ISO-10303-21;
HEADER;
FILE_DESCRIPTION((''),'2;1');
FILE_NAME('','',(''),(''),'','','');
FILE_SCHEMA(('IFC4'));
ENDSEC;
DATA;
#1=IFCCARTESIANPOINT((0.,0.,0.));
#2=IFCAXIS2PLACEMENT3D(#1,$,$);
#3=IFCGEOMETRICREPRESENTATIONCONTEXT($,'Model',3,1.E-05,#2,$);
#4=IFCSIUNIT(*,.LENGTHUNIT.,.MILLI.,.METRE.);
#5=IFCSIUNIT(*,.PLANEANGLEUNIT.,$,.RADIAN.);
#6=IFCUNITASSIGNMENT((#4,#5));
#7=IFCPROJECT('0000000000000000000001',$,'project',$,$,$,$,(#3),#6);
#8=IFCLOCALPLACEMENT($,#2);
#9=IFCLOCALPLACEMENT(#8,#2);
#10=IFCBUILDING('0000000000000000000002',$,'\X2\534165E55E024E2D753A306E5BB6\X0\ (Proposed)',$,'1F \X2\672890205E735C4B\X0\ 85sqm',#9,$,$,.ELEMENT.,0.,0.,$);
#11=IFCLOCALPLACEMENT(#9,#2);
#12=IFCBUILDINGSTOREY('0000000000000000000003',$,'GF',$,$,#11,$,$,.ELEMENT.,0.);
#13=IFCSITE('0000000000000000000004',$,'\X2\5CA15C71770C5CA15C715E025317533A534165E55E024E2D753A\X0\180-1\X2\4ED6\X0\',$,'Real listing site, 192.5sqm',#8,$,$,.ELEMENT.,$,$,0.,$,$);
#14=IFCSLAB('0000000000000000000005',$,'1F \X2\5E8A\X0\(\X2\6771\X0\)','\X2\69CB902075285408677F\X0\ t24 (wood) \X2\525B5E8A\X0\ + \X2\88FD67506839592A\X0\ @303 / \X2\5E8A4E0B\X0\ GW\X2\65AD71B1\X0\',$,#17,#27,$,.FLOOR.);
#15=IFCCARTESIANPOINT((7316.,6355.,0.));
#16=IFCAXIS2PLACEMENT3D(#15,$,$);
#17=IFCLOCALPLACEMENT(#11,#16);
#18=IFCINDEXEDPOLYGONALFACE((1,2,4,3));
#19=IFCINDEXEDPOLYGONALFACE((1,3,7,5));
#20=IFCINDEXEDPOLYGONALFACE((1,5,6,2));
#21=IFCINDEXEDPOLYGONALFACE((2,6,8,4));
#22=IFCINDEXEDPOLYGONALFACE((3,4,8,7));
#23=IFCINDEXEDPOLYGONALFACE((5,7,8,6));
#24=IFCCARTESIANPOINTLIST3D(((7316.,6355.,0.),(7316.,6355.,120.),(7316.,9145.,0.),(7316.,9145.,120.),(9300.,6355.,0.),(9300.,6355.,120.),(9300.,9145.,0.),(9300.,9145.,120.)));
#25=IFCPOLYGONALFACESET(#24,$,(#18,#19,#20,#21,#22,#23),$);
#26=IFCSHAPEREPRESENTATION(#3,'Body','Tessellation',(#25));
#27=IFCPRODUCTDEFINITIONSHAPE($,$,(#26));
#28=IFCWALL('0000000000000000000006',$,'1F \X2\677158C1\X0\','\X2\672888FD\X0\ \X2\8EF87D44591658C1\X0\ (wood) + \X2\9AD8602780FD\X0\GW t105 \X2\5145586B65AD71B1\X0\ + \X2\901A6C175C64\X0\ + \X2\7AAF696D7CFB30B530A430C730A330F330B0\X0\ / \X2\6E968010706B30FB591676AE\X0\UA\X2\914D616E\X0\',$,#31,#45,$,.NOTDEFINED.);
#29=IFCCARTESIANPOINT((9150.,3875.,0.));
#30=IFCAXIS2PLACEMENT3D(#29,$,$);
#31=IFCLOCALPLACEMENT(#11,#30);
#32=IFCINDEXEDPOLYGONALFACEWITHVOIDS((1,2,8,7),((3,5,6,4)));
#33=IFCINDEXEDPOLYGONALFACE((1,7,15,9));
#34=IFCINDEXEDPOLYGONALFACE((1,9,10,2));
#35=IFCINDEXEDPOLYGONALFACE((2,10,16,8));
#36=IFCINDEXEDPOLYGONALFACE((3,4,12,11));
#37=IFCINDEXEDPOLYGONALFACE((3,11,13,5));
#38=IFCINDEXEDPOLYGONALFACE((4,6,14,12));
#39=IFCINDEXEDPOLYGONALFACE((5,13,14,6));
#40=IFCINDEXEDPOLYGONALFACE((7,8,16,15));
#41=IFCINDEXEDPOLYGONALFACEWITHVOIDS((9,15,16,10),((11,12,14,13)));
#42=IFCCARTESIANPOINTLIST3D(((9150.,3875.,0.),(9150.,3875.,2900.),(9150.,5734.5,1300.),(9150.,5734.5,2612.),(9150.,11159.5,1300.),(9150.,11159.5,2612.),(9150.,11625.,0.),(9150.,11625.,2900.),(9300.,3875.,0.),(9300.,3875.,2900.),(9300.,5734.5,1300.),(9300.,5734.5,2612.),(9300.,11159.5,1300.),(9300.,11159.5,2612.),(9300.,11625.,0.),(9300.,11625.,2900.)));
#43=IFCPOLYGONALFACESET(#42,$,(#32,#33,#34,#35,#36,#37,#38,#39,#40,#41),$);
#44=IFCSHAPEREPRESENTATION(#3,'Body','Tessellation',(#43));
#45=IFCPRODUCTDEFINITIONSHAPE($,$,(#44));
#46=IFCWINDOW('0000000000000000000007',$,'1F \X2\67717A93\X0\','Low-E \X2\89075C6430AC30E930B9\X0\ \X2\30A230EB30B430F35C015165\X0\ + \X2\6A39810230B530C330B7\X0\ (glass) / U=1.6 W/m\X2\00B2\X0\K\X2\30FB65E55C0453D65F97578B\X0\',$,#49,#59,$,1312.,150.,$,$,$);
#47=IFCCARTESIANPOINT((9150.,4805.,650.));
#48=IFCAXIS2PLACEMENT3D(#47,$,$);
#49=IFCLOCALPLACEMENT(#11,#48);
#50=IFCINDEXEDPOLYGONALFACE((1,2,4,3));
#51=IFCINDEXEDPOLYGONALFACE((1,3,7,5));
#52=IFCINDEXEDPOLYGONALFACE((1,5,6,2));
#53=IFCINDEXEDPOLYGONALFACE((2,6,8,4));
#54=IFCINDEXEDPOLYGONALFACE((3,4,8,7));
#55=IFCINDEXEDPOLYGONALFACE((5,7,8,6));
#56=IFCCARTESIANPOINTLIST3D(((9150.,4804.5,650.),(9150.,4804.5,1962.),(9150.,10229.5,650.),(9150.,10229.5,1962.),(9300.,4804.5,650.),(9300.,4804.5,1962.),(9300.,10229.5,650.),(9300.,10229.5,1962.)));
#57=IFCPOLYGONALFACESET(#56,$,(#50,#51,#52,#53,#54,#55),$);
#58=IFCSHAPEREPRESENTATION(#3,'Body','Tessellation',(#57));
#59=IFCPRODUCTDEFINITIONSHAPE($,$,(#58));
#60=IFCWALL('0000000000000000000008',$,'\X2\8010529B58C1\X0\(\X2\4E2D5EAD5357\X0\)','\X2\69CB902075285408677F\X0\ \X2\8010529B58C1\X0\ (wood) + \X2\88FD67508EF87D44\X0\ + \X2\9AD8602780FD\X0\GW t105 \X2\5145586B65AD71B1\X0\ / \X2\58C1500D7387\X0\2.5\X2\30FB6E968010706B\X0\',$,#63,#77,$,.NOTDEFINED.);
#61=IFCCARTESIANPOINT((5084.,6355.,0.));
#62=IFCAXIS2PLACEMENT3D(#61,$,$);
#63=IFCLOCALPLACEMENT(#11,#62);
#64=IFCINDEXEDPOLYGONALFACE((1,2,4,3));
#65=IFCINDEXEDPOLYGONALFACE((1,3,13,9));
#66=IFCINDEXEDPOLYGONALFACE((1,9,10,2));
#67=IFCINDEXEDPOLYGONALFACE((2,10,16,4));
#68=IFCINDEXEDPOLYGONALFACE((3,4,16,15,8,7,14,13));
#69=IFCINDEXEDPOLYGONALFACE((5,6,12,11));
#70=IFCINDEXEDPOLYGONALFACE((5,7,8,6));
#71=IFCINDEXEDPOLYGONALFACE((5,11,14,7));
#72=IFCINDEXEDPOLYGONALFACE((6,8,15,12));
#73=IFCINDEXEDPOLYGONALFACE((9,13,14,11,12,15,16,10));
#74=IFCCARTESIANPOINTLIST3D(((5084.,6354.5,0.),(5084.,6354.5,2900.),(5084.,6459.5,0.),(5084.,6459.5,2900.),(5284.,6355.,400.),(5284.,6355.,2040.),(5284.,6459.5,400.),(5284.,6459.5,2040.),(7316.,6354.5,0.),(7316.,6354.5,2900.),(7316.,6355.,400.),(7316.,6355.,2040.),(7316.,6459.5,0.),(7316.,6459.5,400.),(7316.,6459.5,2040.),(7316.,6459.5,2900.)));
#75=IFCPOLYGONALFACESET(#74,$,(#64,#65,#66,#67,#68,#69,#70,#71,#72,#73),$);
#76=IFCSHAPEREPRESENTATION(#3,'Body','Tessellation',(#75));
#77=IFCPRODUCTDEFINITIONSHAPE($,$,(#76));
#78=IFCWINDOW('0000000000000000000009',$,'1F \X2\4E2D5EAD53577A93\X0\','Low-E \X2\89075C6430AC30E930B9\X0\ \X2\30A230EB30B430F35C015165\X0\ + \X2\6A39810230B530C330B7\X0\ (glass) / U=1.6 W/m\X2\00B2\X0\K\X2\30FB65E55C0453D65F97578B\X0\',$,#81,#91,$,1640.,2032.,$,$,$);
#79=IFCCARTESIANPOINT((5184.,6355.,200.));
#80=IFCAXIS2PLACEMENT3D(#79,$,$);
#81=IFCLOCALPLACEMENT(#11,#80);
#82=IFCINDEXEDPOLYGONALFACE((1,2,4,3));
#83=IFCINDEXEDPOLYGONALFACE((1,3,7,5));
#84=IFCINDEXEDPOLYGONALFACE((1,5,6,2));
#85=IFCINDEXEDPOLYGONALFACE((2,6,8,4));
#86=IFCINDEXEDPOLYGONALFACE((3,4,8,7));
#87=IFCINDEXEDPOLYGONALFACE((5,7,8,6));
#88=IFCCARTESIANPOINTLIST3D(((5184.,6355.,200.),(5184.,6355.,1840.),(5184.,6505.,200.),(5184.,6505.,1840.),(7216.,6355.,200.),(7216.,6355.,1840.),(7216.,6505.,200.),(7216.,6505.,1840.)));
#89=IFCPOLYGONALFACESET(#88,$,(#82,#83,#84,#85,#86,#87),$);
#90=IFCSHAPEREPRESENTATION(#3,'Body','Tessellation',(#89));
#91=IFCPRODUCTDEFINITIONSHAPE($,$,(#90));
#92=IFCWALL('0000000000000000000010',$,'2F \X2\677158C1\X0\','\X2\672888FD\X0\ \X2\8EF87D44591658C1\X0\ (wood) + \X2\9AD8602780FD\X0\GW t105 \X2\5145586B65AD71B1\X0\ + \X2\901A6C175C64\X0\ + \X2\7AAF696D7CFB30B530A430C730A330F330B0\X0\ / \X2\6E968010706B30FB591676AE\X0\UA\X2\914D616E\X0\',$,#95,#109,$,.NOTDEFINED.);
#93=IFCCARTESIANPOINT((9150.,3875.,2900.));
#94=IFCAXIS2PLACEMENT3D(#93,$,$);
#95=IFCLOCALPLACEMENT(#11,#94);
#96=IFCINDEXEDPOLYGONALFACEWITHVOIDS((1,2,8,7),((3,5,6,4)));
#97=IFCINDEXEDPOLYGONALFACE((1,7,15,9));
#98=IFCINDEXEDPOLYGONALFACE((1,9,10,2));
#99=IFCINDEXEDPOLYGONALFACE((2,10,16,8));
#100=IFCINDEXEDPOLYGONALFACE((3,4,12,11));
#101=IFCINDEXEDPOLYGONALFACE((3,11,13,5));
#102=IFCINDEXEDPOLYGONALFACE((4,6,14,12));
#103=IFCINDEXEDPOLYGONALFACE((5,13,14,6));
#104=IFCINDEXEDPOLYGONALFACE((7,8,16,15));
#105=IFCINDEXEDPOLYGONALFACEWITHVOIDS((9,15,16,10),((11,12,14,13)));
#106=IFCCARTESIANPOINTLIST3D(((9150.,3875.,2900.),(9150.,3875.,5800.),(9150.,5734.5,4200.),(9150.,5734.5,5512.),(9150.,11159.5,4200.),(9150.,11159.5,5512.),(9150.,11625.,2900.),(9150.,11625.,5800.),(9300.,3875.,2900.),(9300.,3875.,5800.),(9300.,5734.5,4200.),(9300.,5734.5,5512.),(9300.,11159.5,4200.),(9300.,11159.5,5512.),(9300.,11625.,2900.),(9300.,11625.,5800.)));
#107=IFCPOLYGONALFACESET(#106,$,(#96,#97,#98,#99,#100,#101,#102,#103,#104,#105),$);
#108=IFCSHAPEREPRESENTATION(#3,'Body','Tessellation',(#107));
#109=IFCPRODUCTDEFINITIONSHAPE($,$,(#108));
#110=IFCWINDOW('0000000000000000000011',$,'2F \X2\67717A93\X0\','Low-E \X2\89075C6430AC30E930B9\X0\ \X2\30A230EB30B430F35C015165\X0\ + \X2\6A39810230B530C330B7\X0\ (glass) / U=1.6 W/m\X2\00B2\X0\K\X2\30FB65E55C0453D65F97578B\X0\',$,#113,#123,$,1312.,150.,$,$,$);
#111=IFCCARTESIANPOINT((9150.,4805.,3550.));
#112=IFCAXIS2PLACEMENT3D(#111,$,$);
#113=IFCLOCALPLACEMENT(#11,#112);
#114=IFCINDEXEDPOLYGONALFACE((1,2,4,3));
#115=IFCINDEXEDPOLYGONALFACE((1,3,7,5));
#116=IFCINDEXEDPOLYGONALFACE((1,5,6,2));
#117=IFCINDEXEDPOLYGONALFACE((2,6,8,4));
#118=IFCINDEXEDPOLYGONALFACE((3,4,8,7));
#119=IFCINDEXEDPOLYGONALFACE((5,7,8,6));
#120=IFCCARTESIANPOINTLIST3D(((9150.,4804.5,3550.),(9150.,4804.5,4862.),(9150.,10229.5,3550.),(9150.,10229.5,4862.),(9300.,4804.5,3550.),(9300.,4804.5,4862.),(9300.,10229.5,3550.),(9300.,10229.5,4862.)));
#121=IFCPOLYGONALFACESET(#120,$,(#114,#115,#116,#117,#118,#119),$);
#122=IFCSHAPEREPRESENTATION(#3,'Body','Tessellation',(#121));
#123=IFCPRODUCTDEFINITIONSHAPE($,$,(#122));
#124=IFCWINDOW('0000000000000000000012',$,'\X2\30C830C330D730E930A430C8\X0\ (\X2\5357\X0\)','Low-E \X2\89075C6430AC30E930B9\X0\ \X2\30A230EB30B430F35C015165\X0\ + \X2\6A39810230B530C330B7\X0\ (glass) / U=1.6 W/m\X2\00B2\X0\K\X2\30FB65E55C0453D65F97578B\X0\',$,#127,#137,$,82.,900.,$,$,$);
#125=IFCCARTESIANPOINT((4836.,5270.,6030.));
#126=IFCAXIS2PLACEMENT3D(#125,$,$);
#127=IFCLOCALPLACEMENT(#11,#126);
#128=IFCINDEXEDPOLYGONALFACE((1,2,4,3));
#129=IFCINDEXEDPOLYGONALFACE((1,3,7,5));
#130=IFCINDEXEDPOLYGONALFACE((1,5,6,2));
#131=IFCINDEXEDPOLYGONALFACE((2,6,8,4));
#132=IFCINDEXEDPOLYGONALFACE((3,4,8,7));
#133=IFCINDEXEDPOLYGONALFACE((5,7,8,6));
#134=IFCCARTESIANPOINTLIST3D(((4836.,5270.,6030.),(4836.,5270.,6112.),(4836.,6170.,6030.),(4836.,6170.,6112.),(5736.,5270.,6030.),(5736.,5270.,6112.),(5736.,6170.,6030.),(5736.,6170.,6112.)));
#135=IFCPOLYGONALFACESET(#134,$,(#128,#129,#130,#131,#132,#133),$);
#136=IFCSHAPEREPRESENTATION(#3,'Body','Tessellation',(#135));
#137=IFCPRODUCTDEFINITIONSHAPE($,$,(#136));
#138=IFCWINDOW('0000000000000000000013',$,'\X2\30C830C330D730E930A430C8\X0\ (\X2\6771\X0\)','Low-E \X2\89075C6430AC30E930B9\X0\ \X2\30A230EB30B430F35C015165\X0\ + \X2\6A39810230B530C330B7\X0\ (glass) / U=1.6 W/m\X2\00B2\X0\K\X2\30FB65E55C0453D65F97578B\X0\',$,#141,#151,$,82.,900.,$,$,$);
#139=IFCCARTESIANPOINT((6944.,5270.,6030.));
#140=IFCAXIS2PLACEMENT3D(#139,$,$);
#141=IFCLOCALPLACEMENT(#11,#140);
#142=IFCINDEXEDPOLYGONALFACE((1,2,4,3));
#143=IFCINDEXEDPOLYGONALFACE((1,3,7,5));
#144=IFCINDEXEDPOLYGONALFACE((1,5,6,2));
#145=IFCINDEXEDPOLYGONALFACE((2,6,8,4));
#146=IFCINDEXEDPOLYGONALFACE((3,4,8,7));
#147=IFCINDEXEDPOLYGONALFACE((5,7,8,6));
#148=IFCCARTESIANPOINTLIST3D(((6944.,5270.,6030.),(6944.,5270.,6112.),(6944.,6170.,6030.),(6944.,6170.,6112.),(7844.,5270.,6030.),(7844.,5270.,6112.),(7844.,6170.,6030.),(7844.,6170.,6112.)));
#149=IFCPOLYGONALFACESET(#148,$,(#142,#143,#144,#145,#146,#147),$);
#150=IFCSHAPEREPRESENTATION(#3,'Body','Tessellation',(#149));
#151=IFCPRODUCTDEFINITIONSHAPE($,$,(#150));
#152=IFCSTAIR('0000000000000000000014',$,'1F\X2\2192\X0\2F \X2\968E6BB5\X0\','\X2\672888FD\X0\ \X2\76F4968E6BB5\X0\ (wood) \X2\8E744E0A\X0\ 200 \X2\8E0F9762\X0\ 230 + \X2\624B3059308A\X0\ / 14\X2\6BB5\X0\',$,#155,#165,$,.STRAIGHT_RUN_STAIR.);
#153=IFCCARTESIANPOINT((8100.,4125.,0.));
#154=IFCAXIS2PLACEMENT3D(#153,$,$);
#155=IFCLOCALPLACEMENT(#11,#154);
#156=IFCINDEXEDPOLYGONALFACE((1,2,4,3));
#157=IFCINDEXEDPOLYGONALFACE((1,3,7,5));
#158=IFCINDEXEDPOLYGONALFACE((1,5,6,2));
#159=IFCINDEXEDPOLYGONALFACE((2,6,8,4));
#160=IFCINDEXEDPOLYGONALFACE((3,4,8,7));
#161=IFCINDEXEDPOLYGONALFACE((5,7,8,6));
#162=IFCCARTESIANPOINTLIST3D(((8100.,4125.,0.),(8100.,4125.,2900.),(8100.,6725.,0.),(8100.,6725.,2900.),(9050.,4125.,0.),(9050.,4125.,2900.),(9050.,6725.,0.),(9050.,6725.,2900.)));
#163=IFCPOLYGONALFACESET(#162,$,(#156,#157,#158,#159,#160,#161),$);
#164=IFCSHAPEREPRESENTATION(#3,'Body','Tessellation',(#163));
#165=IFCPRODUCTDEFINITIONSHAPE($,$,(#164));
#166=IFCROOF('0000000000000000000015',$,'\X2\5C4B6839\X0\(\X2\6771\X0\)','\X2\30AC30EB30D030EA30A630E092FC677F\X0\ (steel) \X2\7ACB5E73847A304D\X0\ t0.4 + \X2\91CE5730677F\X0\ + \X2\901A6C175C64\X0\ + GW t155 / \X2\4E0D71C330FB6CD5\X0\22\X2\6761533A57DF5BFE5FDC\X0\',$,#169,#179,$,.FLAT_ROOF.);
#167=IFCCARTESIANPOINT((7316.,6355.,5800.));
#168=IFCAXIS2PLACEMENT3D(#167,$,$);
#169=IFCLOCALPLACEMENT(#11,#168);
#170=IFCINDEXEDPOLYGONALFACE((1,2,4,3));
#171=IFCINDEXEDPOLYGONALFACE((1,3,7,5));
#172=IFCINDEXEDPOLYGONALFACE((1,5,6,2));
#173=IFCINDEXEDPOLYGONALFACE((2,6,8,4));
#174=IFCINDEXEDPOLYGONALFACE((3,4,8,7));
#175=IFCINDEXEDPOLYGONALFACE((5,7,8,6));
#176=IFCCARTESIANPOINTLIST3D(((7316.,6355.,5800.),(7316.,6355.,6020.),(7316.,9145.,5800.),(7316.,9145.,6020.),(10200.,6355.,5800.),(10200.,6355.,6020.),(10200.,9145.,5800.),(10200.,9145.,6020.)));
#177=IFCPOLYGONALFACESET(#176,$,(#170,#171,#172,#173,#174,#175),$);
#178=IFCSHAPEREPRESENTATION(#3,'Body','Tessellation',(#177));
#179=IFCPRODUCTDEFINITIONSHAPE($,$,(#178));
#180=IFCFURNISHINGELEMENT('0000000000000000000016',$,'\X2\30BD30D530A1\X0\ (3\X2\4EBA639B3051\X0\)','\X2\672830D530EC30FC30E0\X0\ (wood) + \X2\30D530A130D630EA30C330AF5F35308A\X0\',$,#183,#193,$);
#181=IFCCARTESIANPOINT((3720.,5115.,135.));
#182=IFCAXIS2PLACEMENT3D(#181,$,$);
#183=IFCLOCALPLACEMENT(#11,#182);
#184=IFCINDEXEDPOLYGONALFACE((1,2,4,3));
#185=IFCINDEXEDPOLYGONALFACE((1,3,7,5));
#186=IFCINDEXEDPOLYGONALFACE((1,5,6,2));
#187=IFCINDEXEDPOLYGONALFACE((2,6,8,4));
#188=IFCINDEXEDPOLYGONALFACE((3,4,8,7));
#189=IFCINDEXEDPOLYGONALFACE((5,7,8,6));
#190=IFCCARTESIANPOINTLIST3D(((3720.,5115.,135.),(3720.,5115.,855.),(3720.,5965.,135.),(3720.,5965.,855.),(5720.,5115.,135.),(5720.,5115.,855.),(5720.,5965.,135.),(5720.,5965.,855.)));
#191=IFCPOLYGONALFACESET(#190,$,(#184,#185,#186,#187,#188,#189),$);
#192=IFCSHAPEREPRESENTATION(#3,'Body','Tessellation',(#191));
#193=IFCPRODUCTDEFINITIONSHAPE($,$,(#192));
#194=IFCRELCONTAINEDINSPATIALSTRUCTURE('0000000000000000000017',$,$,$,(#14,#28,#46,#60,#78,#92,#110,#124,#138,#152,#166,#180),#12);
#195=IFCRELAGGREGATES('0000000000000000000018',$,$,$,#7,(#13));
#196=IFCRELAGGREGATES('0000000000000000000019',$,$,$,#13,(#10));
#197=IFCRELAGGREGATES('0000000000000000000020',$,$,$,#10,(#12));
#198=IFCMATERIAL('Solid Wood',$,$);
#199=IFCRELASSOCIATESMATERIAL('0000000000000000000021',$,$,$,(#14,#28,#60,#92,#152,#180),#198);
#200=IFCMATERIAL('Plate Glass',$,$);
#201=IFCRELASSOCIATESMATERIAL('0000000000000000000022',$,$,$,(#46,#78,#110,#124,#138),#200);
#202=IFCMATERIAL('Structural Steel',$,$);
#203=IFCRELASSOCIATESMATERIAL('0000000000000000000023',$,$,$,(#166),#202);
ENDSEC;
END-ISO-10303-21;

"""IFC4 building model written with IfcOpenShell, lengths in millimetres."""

from ifc_helpers import new_model, si_unit, frame, frame_2d, origin, place, context, project, spatial, rectangle, extrude, material, element, fill, save


model = new_model("IFC4")

# Units and contexts
model_context = context("Model", 3, precision=1e-05, world=origin())
ifc_project = project(units=[si_unit("LENGTHUNIT", "METRE", prefix="MILLI"), si_unit("PLANEANGLEUNIT", "RADIAN")], contexts=[model_context])

# Site, building, storey
site_placement = place(None, origin())
site = spatial("IfcSite", under=ifc_project, at=site_placement, Name="岡山県岡山市北区十日市中町180-1他", ObjectType="Real listing site, 192.5sqm", CompositionType="ELEMENT", RefElevation=0.0)
building_placement = place(site_placement, origin())
building = spatial("IfcBuilding", under=site, at=building_placement, Name="十日市中町の家 (Proposed)", ObjectType="1F 木造平屋 85sqm", CompositionType="ELEMENT", ElevationOfRefHeight=0.0, ElevationOfTerrain=0.0)
storey_placement = place(building_placement, origin())
storey = spatial("IfcBuildingStorey", under=building, at=storey_placement, Name="GF", CompositionType="ELEMENT", Elevation=0.0)

# Slab
ifc_material_1 = material(Name="Solid Wood")
slab_placement = place(storey_placement, frame((7316.0, 6355.0, 0.0)))
element("IfcSlab", 1, at=slab_placement, inside=storey, material=ifc_material_1, Name="1F 床(東)", Description="構造用合板 t24 (wood) 剛床 + 製材根太 @303 / 床下 GW断熱", PredefinedType="FLOOR", context=model_context, shape_type="SweptSolid", body=[
    extrude(rectangle(XDim=1984.0, YDim=2790.0, at=frame_2d((992.0, 1395.0))), frame((7316.0, 6355.0, 0.0)), (0.0, 0.0, 1.0), 120.0),
])

# Walls, openings, windows
wall_1_placement = place(storey_placement, frame((9150.0, 3875.0, 0.0)))
wall_1 = element("IfcWall", 2, at=wall_1_placement, inside=storey, material=ifc_material_1, Name="1F 東壁", Description="木製 軸組外壁 (wood) + 高性能GW t105 充填断熱 + 通気層 + 窯業系サイディング / 準耐火・外皮UA配慮", PredefinedType="NOTDEFINED", context=model_context, shape_type="SweptSolid", body=[
    extrude(rectangle(XDim=150.0, YDim=7750.0, at=frame_2d((75.0, 3875.0))), frame((9150.0, 3875.0, 0.0)), (0.0, 0.0, 1.0), 2900.0),
])
opening_1_placement = place(storey_placement, frame((9150.0, 4805.0, 650.0)))
opening_1 = element("IfcOpeningElement", 3, at=opening_1_placement, cuts=wall_1, PredefinedType="NOTDEFINED", context=model_context, shape_type="SweptSolid", body=[
    extrude(rectangle(XDim=150.0, YDim=5425.0, at=frame_2d((75.0, 2712.0))), frame((9150.0, 4805.0, 650.0)), (0.0, 0.0, 1.0), 1312.0),
])
ifc_material_2 = material(Name="Plate Glass")
window_1_placement = place(storey_placement, frame((9150.0, 4805.0, 650.0)))
window_1 = element("IfcWindow", 4, at=window_1_placement, inside=storey, material=ifc_material_2, Name="1F 東窓", Description="Low-E 複層ガラス アルゴン封入 + 樹脂サッシ (glass) / U=1.6 W/m²K・日射取得型", OverallHeight=1312.0, OverallWidth=150.0, context=model_context, shape_type="SweptSolid", body=[
    extrude(rectangle(XDim=150.0, YDim=5425.0, at=frame_2d((75.0, 2712.0))), frame((9150.0, 4805.0, 650.0)), (0.0, 0.0, 1.0), 1312.0),
])
fill(opening_1, window_1)
wall_2_placement = place(storey_placement, frame((5084.0, 6355.0, 0.0)))
wall_2 = element("IfcWall", 5, at=wall_2_placement, inside=storey, material=ifc_material_1, Name="耐力壁(中庭南)", Description="構造用合板 耐力壁 (wood) + 製材軸組 + 高性能GW t105 充填断熱 / 壁倍率2.5・準耐火", PredefinedType="NOTDEFINED", context=model_context, shape_type="SweptSolid", body=[
    extrude(rectangle(XDim=2232.0, YDim=105.0, at=frame_2d((1116.0, 52.0))), frame((5084.0, 6355.0, 0.0)), (0.0, 0.0, 1.0), 2900.0),
])
opening_2_placement = place(storey_placement, frame((5184.0, 6355.0, 200.0)))
opening_2 = element("IfcOpeningElement", 6, at=opening_2_placement, cuts=wall_2, PredefinedType="NOTDEFINED", context=model_context, shape_type="SweptSolid", body=[
    extrude(rectangle(XDim=2032.0, YDim=150.0, at=frame_2d((1016.0, 75.0))), frame((5184.0, 6355.0, 200.0)), (0.0, 0.0, 1.0), 1640.0),
])
window_2_placement = place(storey_placement, frame((5184.0, 6355.0, 200.0)))
window_2 = element("IfcWindow", 7, at=window_2_placement, inside=storey, material=ifc_material_2, Name="1F 中庭南窓", Description="Low-E 複層ガラス アルゴン封入 + 樹脂サッシ (glass) / U=1.6 W/m²K・日射取得型", OverallHeight=1640.0, OverallWidth=2032.0, context=model_context, shape_type="SweptSolid", body=[
    extrude(rectangle(XDim=2032.0, YDim=150.0, at=frame_2d((1016.0, 75.0))), frame((5184.0, 6355.0, 200.0)), (0.0, 0.0, 1.0), 1640.0),
])
fill(opening_2, window_2)

# Wall, opening, window
wall_3_placement = place(storey_placement, frame((9150.0, 3875.0, 2900.0)))
wall_3 = element("IfcWall", 8, at=wall_3_placement, inside=storey, material=ifc_material_1, Name="2F 東壁", Description="木製 軸組外壁 (wood) + 高性能GW t105 充填断熱 + 通気層 + 窯業系サイディング / 準耐火・外皮UA配慮", PredefinedType="NOTDEFINED", context=model_context, shape_type="SweptSolid", body=[
    extrude(rectangle(XDim=150.0, YDim=7750.0, at=frame_2d((75.0, 3875.0))), frame((9150.0, 3875.0, 2900.0)), (0.0, 0.0, 1.0), 2900.0),
])
opening_3_placement = place(storey_placement, frame((9150.0, 4805.0, 3550.0)))
opening_3 = element("IfcOpeningElement", 9, at=opening_3_placement, cuts=wall_3, PredefinedType="NOTDEFINED", context=model_context, shape_type="SweptSolid", body=[
    extrude(rectangle(XDim=150.0, YDim=5425.0, at=frame_2d((75.0, 2712.0))), frame((9150.0, 4805.0, 3550.0)), (0.0, 0.0, 1.0), 1312.0),
])
window_3_placement = place(storey_placement, frame((9150.0, 4805.0, 3550.0)))
window_3 = element("IfcWindow", 10, at=window_3_placement, inside=storey, material=ifc_material_2, Name="2F 東窓", Description="Low-E 複層ガラス アルゴン封入 + 樹脂サッシ (glass) / U=1.6 W/m²K・日射取得型", OverallHeight=1312.0, OverallWidth=150.0, context=model_context, shape_type="SweptSolid", body=[
    extrude(rectangle(XDim=150.0, YDim=5425.0, at=frame_2d((75.0, 2712.0))), frame((9150.0, 4805.0, 3550.0)), (0.0, 0.0, 1.0), 1312.0),
])
fill(opening_3, window_3)

# Windows
window_4_placement = place(storey_placement, frame((4836.0, 5270.0, 6030.0)))
element("IfcWindow", 11, at=window_4_placement, inside=storey, material=ifc_material_2, Name="トップライト (南)", Description="Low-E 複層ガラス アルゴン封入 + 樹脂サッシ (glass) / U=1.6 W/m²K・日射取得型", OverallHeight=82.0, OverallWidth=900.0, context=model_context, shape_type="SweptSolid", body=[
    extrude(rectangle(XDim=900.0, YDim=900.0, at=frame_2d((450.0, 450.0))), frame((4836.0, 5270.0, 6030.0)), (0.0, 0.0, 1.0), 82.0),
])
window_5_placement = place(storey_placement, frame((6944.0, 5270.0, 6030.0)))
element("IfcWindow", 12, at=window_5_placement, inside=storey, material=ifc_material_2, Name="トップライト (東)", Description="Low-E 複層ガラス アルゴン封入 + 樹脂サッシ (glass) / U=1.6 W/m²K・日射取得型", OverallHeight=82.0, OverallWidth=900.0, context=model_context, shape_type="SweptSolid", body=[
    extrude(rectangle(XDim=900.0, YDim=900.0, at=frame_2d((450.0, 450.0))), frame((6944.0, 5270.0, 6030.0)), (0.0, 0.0, 1.0), 82.0),
])

# Stair
stair_placement = place(storey_placement, frame((8100.0, 4125.0, 0.0)))
element("IfcStair", 13, at=stair_placement, inside=storey, material=ifc_material_1, Name="1F→2F 階段", Description="木製 直階段 (wood) 蹴上 200 踏面 230 + 手すり / 14段", PredefinedType="STRAIGHT_RUN_STAIR", context=model_context, shape_type="SweptSolid", body=[
    extrude(rectangle(XDim=950.0, YDim=2600.0, at=frame_2d((475.0, 1300.0))), frame((8100.0, 4125.0, 0.0)), (0.0, 0.0, 1.0), 2900.0),
])

# Roof
ifc_material_3 = material(Name="Structural Steel")
roof_placement = place(storey_placement, frame((7316.0, 6355.0, 5800.0)))
element("IfcRoof", 14, at=roof_placement, inside=storey, material=ifc_material_3, Name="屋根(東)", Description="ガルバリウム鋼板 (steel) 立平葺き t0.4 + 野地板 + 通気層 + GW t155 / 不燃・法22条区域対応", PredefinedType="FLAT_ROOF", context=model_context, shape_type="SweptSolid", body=[
    extrude(rectangle(XDim=2884.0, YDim=2790.0, at=frame_2d((1442.0, 1395.0))), frame((7316.0, 6355.0, 5800.0)), (0.0, 0.0, 1.0), 220.0),
])

# Furnishing element
furnishing_1_placement = place(storey_placement, frame((3720.0, 5115.0, 135.0)))
element("IfcFurnishingElement", 15, at=furnishing_1_placement, inside=storey, material=ifc_material_1, Name="ソファ (3人掛け)", Description="木フレーム (wood) + ファブリック張り", context=model_context, shape_type="SweptSolid", body=[
    extrude(rectangle(XDim=2000.0, YDim=850.0, at=frame_2d((1000.0, 425.0))), frame((3720.0, 5115.0, 135.0)), (0.0, 0.0, 1.0), 720.0),
])

save(model, "model.ifc")
